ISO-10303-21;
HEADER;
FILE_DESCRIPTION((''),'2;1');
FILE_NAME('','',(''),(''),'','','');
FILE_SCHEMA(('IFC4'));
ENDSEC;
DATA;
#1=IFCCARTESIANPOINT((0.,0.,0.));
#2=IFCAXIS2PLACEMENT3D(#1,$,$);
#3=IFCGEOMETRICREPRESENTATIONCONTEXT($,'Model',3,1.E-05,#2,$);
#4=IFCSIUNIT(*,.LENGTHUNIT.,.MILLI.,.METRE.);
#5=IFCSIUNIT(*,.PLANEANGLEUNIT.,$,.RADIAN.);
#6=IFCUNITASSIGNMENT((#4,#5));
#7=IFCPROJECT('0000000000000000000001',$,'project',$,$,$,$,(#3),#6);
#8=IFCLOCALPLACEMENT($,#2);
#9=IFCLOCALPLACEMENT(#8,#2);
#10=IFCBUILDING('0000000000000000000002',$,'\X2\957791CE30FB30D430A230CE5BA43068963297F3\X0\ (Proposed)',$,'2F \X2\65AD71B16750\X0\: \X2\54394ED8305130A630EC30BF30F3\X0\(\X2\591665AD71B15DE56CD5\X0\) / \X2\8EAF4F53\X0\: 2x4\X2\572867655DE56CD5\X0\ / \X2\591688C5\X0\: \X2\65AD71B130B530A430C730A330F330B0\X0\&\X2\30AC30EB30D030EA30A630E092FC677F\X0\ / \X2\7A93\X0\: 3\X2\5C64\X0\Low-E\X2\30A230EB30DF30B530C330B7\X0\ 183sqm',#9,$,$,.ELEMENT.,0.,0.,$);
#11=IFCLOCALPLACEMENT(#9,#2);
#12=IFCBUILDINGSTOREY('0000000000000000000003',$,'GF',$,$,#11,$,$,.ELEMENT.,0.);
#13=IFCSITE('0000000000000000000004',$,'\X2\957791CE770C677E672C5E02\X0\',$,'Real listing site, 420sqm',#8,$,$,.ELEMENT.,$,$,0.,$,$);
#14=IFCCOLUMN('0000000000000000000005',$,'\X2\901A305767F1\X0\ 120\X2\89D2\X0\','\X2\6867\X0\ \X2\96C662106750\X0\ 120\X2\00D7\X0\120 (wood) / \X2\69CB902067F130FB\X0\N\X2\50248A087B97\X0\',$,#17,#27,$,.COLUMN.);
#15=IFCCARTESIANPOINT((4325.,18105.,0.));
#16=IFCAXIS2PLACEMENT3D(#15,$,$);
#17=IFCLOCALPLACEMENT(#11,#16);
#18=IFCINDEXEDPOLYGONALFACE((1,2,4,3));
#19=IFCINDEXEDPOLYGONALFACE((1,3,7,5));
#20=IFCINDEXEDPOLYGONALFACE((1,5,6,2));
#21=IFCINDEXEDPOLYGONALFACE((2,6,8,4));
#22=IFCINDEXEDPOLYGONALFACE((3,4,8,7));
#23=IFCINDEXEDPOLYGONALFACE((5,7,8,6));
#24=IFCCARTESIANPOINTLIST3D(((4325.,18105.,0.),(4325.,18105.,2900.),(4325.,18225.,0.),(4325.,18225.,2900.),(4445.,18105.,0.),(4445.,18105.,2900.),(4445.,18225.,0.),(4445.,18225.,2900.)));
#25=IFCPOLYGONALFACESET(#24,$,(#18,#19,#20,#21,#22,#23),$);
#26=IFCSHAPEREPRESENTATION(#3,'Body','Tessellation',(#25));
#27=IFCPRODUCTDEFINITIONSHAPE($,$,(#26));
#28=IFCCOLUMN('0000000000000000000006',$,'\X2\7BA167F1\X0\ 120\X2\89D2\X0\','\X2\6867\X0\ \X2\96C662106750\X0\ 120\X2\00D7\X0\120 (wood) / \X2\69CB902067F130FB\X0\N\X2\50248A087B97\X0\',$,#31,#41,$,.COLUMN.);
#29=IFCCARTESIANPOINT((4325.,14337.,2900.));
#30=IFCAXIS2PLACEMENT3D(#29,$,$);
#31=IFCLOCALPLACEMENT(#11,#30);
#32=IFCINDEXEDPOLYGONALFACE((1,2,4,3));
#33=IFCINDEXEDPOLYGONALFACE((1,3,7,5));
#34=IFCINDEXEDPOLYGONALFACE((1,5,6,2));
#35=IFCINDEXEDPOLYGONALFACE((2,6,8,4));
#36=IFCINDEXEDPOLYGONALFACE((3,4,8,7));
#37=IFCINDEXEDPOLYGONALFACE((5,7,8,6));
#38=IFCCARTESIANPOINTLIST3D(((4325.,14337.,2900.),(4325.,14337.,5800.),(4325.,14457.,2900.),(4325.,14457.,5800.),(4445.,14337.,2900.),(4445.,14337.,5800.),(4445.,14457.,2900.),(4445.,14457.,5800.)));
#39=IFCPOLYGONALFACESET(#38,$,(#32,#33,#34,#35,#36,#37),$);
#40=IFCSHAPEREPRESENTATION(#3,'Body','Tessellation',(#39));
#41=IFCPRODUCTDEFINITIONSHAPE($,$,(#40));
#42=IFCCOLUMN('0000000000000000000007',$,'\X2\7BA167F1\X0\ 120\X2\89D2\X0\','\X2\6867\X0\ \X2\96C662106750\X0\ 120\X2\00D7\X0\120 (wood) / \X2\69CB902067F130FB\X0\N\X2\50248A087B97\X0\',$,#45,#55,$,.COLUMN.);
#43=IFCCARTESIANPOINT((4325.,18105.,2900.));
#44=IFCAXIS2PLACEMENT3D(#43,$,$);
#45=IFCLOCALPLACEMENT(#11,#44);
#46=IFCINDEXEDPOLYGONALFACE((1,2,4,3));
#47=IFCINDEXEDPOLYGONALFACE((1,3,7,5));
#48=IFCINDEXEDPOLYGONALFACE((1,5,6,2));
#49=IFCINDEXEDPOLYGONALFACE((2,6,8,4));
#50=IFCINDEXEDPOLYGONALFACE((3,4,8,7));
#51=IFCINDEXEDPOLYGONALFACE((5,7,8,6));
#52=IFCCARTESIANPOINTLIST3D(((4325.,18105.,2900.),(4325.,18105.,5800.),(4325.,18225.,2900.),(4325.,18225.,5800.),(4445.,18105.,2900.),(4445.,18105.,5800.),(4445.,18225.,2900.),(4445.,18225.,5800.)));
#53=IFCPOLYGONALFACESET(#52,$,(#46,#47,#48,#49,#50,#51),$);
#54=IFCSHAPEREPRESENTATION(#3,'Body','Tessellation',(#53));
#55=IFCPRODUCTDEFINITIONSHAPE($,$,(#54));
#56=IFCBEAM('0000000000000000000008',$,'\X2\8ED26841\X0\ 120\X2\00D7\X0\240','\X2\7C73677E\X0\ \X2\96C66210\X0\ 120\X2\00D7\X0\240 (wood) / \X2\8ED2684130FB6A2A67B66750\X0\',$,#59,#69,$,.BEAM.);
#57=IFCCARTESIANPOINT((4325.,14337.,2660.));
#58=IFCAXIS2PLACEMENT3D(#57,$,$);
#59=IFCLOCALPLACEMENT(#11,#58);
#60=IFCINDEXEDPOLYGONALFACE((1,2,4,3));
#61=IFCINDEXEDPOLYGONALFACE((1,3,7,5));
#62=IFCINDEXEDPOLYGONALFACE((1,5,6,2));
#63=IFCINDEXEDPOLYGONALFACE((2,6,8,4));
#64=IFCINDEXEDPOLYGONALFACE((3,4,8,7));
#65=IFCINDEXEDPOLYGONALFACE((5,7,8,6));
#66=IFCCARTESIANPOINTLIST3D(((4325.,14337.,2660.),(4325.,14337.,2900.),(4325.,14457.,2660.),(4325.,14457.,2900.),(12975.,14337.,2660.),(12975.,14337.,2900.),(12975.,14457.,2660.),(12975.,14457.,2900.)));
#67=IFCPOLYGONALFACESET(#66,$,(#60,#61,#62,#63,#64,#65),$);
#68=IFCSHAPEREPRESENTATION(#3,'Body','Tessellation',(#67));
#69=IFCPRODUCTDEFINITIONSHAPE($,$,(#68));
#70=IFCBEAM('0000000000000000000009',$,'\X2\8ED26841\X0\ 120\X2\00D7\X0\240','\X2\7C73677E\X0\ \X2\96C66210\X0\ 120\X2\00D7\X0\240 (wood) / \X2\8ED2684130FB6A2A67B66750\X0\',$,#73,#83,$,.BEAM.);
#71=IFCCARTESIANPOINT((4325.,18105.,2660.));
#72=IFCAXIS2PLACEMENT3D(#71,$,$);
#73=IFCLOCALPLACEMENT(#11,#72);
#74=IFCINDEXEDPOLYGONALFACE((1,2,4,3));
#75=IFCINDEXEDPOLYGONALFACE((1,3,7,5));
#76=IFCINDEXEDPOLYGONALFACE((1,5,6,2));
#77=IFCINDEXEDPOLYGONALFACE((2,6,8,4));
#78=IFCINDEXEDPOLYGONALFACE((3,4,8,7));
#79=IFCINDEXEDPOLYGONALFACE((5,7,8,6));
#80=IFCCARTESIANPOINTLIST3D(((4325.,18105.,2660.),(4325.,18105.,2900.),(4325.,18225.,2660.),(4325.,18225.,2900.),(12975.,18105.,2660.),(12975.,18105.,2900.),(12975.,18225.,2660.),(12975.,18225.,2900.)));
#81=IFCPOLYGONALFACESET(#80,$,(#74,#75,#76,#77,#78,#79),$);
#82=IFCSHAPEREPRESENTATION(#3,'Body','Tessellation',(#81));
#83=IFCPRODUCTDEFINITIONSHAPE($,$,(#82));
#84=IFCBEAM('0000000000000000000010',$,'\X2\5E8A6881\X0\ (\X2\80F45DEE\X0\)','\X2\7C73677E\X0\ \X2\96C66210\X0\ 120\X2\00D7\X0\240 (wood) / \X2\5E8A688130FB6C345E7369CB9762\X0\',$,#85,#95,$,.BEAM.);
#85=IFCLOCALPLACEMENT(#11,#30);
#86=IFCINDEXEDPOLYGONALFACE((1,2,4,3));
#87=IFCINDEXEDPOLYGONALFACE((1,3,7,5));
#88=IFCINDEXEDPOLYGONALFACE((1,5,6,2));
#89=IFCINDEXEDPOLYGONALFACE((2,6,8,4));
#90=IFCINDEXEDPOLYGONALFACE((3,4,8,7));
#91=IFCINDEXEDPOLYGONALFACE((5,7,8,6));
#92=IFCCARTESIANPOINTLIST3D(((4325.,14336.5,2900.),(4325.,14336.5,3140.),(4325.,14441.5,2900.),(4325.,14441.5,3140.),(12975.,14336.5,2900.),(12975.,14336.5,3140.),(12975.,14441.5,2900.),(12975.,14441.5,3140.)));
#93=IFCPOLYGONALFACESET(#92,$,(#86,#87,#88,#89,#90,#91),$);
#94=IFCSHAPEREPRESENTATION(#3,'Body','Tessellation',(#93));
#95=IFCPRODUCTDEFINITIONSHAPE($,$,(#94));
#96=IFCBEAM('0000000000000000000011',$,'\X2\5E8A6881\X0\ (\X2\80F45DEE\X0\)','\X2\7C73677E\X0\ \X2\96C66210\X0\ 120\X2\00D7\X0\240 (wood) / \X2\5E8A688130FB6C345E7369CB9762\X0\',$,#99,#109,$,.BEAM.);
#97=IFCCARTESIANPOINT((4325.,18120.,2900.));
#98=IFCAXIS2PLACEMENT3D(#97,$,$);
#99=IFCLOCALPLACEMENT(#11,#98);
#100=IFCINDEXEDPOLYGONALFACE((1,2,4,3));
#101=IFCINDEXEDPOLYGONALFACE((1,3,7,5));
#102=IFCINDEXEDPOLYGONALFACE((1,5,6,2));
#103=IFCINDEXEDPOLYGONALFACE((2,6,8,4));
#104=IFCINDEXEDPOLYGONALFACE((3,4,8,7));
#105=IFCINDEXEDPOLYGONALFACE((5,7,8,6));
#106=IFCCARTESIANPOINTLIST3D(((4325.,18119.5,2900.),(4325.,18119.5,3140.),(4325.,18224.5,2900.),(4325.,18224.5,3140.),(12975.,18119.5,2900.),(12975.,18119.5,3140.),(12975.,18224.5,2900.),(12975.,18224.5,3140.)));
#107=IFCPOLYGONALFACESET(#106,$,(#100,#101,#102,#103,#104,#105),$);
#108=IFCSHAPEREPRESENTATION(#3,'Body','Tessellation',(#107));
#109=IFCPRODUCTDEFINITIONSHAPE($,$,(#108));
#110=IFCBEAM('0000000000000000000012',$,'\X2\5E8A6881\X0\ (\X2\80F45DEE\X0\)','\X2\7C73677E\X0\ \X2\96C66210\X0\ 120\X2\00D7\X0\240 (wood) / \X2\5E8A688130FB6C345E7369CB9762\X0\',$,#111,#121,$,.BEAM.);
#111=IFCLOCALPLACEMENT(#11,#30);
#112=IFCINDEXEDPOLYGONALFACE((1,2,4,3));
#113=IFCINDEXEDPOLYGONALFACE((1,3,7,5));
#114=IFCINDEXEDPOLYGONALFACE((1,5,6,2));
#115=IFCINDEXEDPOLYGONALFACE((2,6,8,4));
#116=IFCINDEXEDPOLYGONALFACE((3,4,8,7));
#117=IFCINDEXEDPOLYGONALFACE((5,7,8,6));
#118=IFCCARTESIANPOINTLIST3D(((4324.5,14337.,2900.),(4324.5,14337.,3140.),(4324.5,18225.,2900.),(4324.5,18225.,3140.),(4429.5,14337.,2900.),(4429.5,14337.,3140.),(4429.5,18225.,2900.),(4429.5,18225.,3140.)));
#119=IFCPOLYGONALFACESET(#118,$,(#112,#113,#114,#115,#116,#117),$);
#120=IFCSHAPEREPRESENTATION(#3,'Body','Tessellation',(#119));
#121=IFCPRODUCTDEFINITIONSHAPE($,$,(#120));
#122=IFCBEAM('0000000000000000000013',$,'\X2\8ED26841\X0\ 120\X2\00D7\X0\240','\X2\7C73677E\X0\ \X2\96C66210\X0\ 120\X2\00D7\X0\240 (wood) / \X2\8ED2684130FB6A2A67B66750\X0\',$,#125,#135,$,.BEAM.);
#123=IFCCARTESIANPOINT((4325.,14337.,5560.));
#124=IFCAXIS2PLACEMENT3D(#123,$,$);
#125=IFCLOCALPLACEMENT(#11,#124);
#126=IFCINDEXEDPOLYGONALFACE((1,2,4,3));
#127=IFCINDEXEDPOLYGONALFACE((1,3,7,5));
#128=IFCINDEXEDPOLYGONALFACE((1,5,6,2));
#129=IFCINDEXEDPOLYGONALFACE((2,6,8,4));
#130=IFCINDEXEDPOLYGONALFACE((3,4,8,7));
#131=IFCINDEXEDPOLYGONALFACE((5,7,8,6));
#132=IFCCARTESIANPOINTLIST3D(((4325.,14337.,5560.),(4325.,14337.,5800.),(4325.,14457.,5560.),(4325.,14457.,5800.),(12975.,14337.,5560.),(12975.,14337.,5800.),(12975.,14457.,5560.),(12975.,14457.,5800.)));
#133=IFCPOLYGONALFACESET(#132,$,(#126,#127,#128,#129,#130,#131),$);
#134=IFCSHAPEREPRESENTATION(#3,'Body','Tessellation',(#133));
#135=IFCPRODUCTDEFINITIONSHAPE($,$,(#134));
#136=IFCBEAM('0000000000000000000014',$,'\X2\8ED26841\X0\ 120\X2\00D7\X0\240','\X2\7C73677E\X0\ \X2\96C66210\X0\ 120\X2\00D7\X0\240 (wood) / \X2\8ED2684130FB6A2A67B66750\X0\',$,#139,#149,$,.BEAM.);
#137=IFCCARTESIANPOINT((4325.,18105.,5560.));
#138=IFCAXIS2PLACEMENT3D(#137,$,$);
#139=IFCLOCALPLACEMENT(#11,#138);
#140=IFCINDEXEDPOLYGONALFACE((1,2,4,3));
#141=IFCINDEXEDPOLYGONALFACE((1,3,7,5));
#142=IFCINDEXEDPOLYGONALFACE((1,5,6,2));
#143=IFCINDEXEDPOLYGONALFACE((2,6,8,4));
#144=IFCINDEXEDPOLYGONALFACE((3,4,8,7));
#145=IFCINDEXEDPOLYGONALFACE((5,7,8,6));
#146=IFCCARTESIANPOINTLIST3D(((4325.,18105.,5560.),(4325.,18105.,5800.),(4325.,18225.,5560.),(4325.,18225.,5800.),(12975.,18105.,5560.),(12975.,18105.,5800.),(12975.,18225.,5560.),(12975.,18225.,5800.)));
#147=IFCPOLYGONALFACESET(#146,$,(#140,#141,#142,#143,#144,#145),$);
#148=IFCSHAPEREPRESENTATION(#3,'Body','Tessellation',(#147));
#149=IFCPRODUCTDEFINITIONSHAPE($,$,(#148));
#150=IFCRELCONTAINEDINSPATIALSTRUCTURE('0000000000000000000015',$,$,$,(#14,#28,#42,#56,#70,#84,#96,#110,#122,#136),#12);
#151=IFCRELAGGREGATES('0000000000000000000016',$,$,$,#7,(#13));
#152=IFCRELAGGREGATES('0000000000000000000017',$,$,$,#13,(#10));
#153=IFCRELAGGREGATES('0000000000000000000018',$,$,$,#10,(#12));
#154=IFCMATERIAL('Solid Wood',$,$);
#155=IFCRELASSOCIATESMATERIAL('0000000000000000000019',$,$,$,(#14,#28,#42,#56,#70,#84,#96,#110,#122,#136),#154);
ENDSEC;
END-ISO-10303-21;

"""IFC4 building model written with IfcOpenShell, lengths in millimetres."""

from ifc_helpers import new_model, si_unit, frame, frame_2d, origin, place, context, project, spatial, rectangle, extrude, material, element, save


model = new_model("IFC4")

# Units and contexts
model_context = context("Model", 3, precision=1e-05, world=origin())
ifc_project = project(units=[si_unit("LENGTHUNIT", "METRE", prefix="MILLI"), si_unit("PLANEANGLEUNIT", "RADIAN")], contexts=[model_context])

# Site, building, storey
site_placement = place(None, origin())
site = spatial("IfcSite", under=ifc_project, at=site_placement, Name="長野県松本市", ObjectType="Real listing site, 420sqm", CompositionType="ELEMENT", RefElevation=0.0)
building_placement = place(site_placement, origin())
building = spatial("IfcBuilding", under=site, at=building_placement, Name="長野・ピアノ室と防音 (Proposed)", ObjectType="2F 断熱材: 吹付けウレタン(外断熱工法) / 躯体: 2x4在来工法 / 外装: 断熱サイディング&ガルバリウム鋼板 / 窓: 3層Low-Eアルミサッシ 183sqm", CompositionType="ELEMENT", ElevationOfRefHeight=0.0, ElevationOfTerrain=0.0)
storey_placement = place(building_placement, origin())
storey = spatial("IfcBuildingStorey", under=building, at=storey_placement, Name="GF", CompositionType="ELEMENT", Elevation=0.0)

# Columns
ifc_material_1 = material(Name="Solid Wood")
column_1_placement = place(storey_placement, frame((4325.0, 18105.0, 0.0)))
element("IfcColumn", 1, at=column_1_placement, inside=storey, material=ifc_material_1, Name="通し柱 120角", Description="桧 集成材 120×120 (wood) / 構造柱・N値計算", PredefinedType="COLUMN", context=model_context, shape_type="SweptSolid", body=[
    extrude(rectangle(XDim=120.0, YDim=120.0, at=frame_2d((60.0, 60.0))), frame((4325.0, 18105.0, 0.0)), (0.0, 0.0, 1.0), 2900.0),
])
column_2_placement = place(storey_placement, frame((4325.0, 14337.0, 2900.0)))
element("IfcColumn", 2, at=column_2_placement, inside=storey, material=ifc_material_1, Name="管柱 120角", Description="桧 集成材 120×120 (wood) / 構造柱・N値計算", PredefinedType="COLUMN", context=model_context, shape_type="SweptSolid", body=[
    extrude(rectangle(XDim=120.0, YDim=120.0, at=frame_2d((60.0, 60.0))), frame((4325.0, 14337.0, 2900.0)), (0.0, 0.0, 1.0), 2900.0),
])
column_3_placement = place(storey_placement, frame((4325.0, 18105.0, 2900.0)))
element("IfcColumn", 3, at=column_3_placement, inside=storey, material=ifc_material_1, Name="管柱 120角", Description="桧 集成材 120×120 (wood) / 構造柱・N値計算", PredefinedType="COLUMN", context=model_context, shape_type="SweptSolid", body=[
    extrude(rectangle(XDim=120.0, YDim=120.0, at=frame_2d((60.0, 60.0))), frame((4325.0, 18105.0, 2900.0)), (0.0, 0.0, 1.0), 2900.0),
])

# Beams
beam_1_placement = place(storey_placement, frame((4325.0, 14337.0, 2660.0)))
element("IfcBeam", 4, at=beam_1_placement, inside=storey, material=ifc_material_1, Name="軒桁 120×240", Description="米松 集成 120×240 (wood) / 軒桁・横架材", PredefinedType="BEAM", context=model_context, shape_type="SweptSolid", body=[
    extrude(rectangle(XDim=8650.0, YDim=120.0, at=frame_2d((4325.0, 60.0))), frame((4325.0, 14337.0, 2660.0)), (0.0, 0.0, 1.0), 240.0),
])
beam_2_placement = place(storey_placement, frame((4325.0, 18105.0, 2660.0)))
element("IfcBeam", 5, at=beam_2_placement, inside=storey, material=ifc_material_1, Name="軒桁 120×240", Description="米松 集成 120×240 (wood) / 軒桁・横架材", PredefinedType="BEAM", context=model_context, shape_type="SweptSolid", body=[
    extrude(rectangle(XDim=8650.0, YDim=120.0, at=frame_2d((4325.0, 60.0))), frame((4325.0, 18105.0, 2660.0)), (0.0, 0.0, 1.0), 240.0),
])
beam_3_placement = place(storey_placement, frame((4325.0, 14337.0, 2900.0)))
element("IfcBeam", 6, at=beam_3_placement, inside=storey, material=ifc_material_1, Name="床梁 (胴差)", Description="米松 集成 120×240 (wood) / 床梁・水平構面", PredefinedType="BEAM", context=model_context, shape_type="SweptSolid", body=[
    extrude(rectangle(XDim=8650.0, YDim=105.0, at=frame_2d((4325.0, 52.0))), frame((4325.0, 14337.0, 2900.0)), (0.0, 0.0, 1.0), 240.0),
])
beam_4_placement = place(storey_placement, frame((4325.0, 18120.0, 2900.0)))
element("IfcBeam", 7, at=beam_4_placement, inside=storey, material=ifc_material_1, Name="床梁 (胴差)", Description="米松 集成 120×240 (wood) / 床梁・水平構面", PredefinedType="BEAM", context=model_context, shape_type="SweptSolid", body=[
    extrude(rectangle(XDim=8650.0, YDim=105.0, at=frame_2d((4325.0, 52.0))), frame((4325.0, 18120.0, 2900.0)), (0.0, 0.0, 1.0), 240.0),
])
beam_5_placement = place(storey_placement, frame((4325.0, 14337.0, 2900.0)))
element("IfcBeam", 8, at=beam_5_placement, inside=storey, material=ifc_material_1, Name="床梁 (胴差)", Description="米松 集成 120×240 (wood) / 床梁・水平構面", PredefinedType="BEAM", context=model_context, shape_type="SweptSolid", body=[
    extrude(rectangle(XDim=105.0, YDim=3888.0, at=frame_2d((52.0, 1944.0))), frame((4325.0, 14337.0, 2900.0)), (0.0, 0.0, 1.0), 240.0),
])
beam_6_placement = place(storey_placement, frame((4325.0, 14337.0, 5560.0)))
element("IfcBeam", 9, at=beam_6_placement, inside=storey, material=ifc_material_1, Name="軒桁 120×240", Description="米松 集成 120×240 (wood) / 軒桁・横架材", PredefinedType="BEAM", context=model_context, shape_type="SweptSolid", body=[
    extrude(rectangle(XDim=8650.0, YDim=120.0, at=frame_2d((4325.0, 60.0))), frame((4325.0, 14337.0, 5560.0)), (0.0, 0.0, 1.0), 240.0),
])
beam_7_placement = place(storey_placement, frame((4325.0, 18105.0, 5560.0)))
element("IfcBeam", 10, at=beam_7_placement, inside=storey, material=ifc_material_1, Name="軒桁 120×240", Description="米松 集成 120×240 (wood) / 軒桁・横架材", PredefinedType="BEAM", context=model_context, shape_type="SweptSolid", body=[
    extrude(rectangle(XDim=8650.0, YDim=120.0, at=frame_2d((4325.0, 60.0))), frame((4325.0, 18105.0, 5560.0)), (0.0, 0.0, 1.0), 240.0),
])

save(model, "model.ifc")
